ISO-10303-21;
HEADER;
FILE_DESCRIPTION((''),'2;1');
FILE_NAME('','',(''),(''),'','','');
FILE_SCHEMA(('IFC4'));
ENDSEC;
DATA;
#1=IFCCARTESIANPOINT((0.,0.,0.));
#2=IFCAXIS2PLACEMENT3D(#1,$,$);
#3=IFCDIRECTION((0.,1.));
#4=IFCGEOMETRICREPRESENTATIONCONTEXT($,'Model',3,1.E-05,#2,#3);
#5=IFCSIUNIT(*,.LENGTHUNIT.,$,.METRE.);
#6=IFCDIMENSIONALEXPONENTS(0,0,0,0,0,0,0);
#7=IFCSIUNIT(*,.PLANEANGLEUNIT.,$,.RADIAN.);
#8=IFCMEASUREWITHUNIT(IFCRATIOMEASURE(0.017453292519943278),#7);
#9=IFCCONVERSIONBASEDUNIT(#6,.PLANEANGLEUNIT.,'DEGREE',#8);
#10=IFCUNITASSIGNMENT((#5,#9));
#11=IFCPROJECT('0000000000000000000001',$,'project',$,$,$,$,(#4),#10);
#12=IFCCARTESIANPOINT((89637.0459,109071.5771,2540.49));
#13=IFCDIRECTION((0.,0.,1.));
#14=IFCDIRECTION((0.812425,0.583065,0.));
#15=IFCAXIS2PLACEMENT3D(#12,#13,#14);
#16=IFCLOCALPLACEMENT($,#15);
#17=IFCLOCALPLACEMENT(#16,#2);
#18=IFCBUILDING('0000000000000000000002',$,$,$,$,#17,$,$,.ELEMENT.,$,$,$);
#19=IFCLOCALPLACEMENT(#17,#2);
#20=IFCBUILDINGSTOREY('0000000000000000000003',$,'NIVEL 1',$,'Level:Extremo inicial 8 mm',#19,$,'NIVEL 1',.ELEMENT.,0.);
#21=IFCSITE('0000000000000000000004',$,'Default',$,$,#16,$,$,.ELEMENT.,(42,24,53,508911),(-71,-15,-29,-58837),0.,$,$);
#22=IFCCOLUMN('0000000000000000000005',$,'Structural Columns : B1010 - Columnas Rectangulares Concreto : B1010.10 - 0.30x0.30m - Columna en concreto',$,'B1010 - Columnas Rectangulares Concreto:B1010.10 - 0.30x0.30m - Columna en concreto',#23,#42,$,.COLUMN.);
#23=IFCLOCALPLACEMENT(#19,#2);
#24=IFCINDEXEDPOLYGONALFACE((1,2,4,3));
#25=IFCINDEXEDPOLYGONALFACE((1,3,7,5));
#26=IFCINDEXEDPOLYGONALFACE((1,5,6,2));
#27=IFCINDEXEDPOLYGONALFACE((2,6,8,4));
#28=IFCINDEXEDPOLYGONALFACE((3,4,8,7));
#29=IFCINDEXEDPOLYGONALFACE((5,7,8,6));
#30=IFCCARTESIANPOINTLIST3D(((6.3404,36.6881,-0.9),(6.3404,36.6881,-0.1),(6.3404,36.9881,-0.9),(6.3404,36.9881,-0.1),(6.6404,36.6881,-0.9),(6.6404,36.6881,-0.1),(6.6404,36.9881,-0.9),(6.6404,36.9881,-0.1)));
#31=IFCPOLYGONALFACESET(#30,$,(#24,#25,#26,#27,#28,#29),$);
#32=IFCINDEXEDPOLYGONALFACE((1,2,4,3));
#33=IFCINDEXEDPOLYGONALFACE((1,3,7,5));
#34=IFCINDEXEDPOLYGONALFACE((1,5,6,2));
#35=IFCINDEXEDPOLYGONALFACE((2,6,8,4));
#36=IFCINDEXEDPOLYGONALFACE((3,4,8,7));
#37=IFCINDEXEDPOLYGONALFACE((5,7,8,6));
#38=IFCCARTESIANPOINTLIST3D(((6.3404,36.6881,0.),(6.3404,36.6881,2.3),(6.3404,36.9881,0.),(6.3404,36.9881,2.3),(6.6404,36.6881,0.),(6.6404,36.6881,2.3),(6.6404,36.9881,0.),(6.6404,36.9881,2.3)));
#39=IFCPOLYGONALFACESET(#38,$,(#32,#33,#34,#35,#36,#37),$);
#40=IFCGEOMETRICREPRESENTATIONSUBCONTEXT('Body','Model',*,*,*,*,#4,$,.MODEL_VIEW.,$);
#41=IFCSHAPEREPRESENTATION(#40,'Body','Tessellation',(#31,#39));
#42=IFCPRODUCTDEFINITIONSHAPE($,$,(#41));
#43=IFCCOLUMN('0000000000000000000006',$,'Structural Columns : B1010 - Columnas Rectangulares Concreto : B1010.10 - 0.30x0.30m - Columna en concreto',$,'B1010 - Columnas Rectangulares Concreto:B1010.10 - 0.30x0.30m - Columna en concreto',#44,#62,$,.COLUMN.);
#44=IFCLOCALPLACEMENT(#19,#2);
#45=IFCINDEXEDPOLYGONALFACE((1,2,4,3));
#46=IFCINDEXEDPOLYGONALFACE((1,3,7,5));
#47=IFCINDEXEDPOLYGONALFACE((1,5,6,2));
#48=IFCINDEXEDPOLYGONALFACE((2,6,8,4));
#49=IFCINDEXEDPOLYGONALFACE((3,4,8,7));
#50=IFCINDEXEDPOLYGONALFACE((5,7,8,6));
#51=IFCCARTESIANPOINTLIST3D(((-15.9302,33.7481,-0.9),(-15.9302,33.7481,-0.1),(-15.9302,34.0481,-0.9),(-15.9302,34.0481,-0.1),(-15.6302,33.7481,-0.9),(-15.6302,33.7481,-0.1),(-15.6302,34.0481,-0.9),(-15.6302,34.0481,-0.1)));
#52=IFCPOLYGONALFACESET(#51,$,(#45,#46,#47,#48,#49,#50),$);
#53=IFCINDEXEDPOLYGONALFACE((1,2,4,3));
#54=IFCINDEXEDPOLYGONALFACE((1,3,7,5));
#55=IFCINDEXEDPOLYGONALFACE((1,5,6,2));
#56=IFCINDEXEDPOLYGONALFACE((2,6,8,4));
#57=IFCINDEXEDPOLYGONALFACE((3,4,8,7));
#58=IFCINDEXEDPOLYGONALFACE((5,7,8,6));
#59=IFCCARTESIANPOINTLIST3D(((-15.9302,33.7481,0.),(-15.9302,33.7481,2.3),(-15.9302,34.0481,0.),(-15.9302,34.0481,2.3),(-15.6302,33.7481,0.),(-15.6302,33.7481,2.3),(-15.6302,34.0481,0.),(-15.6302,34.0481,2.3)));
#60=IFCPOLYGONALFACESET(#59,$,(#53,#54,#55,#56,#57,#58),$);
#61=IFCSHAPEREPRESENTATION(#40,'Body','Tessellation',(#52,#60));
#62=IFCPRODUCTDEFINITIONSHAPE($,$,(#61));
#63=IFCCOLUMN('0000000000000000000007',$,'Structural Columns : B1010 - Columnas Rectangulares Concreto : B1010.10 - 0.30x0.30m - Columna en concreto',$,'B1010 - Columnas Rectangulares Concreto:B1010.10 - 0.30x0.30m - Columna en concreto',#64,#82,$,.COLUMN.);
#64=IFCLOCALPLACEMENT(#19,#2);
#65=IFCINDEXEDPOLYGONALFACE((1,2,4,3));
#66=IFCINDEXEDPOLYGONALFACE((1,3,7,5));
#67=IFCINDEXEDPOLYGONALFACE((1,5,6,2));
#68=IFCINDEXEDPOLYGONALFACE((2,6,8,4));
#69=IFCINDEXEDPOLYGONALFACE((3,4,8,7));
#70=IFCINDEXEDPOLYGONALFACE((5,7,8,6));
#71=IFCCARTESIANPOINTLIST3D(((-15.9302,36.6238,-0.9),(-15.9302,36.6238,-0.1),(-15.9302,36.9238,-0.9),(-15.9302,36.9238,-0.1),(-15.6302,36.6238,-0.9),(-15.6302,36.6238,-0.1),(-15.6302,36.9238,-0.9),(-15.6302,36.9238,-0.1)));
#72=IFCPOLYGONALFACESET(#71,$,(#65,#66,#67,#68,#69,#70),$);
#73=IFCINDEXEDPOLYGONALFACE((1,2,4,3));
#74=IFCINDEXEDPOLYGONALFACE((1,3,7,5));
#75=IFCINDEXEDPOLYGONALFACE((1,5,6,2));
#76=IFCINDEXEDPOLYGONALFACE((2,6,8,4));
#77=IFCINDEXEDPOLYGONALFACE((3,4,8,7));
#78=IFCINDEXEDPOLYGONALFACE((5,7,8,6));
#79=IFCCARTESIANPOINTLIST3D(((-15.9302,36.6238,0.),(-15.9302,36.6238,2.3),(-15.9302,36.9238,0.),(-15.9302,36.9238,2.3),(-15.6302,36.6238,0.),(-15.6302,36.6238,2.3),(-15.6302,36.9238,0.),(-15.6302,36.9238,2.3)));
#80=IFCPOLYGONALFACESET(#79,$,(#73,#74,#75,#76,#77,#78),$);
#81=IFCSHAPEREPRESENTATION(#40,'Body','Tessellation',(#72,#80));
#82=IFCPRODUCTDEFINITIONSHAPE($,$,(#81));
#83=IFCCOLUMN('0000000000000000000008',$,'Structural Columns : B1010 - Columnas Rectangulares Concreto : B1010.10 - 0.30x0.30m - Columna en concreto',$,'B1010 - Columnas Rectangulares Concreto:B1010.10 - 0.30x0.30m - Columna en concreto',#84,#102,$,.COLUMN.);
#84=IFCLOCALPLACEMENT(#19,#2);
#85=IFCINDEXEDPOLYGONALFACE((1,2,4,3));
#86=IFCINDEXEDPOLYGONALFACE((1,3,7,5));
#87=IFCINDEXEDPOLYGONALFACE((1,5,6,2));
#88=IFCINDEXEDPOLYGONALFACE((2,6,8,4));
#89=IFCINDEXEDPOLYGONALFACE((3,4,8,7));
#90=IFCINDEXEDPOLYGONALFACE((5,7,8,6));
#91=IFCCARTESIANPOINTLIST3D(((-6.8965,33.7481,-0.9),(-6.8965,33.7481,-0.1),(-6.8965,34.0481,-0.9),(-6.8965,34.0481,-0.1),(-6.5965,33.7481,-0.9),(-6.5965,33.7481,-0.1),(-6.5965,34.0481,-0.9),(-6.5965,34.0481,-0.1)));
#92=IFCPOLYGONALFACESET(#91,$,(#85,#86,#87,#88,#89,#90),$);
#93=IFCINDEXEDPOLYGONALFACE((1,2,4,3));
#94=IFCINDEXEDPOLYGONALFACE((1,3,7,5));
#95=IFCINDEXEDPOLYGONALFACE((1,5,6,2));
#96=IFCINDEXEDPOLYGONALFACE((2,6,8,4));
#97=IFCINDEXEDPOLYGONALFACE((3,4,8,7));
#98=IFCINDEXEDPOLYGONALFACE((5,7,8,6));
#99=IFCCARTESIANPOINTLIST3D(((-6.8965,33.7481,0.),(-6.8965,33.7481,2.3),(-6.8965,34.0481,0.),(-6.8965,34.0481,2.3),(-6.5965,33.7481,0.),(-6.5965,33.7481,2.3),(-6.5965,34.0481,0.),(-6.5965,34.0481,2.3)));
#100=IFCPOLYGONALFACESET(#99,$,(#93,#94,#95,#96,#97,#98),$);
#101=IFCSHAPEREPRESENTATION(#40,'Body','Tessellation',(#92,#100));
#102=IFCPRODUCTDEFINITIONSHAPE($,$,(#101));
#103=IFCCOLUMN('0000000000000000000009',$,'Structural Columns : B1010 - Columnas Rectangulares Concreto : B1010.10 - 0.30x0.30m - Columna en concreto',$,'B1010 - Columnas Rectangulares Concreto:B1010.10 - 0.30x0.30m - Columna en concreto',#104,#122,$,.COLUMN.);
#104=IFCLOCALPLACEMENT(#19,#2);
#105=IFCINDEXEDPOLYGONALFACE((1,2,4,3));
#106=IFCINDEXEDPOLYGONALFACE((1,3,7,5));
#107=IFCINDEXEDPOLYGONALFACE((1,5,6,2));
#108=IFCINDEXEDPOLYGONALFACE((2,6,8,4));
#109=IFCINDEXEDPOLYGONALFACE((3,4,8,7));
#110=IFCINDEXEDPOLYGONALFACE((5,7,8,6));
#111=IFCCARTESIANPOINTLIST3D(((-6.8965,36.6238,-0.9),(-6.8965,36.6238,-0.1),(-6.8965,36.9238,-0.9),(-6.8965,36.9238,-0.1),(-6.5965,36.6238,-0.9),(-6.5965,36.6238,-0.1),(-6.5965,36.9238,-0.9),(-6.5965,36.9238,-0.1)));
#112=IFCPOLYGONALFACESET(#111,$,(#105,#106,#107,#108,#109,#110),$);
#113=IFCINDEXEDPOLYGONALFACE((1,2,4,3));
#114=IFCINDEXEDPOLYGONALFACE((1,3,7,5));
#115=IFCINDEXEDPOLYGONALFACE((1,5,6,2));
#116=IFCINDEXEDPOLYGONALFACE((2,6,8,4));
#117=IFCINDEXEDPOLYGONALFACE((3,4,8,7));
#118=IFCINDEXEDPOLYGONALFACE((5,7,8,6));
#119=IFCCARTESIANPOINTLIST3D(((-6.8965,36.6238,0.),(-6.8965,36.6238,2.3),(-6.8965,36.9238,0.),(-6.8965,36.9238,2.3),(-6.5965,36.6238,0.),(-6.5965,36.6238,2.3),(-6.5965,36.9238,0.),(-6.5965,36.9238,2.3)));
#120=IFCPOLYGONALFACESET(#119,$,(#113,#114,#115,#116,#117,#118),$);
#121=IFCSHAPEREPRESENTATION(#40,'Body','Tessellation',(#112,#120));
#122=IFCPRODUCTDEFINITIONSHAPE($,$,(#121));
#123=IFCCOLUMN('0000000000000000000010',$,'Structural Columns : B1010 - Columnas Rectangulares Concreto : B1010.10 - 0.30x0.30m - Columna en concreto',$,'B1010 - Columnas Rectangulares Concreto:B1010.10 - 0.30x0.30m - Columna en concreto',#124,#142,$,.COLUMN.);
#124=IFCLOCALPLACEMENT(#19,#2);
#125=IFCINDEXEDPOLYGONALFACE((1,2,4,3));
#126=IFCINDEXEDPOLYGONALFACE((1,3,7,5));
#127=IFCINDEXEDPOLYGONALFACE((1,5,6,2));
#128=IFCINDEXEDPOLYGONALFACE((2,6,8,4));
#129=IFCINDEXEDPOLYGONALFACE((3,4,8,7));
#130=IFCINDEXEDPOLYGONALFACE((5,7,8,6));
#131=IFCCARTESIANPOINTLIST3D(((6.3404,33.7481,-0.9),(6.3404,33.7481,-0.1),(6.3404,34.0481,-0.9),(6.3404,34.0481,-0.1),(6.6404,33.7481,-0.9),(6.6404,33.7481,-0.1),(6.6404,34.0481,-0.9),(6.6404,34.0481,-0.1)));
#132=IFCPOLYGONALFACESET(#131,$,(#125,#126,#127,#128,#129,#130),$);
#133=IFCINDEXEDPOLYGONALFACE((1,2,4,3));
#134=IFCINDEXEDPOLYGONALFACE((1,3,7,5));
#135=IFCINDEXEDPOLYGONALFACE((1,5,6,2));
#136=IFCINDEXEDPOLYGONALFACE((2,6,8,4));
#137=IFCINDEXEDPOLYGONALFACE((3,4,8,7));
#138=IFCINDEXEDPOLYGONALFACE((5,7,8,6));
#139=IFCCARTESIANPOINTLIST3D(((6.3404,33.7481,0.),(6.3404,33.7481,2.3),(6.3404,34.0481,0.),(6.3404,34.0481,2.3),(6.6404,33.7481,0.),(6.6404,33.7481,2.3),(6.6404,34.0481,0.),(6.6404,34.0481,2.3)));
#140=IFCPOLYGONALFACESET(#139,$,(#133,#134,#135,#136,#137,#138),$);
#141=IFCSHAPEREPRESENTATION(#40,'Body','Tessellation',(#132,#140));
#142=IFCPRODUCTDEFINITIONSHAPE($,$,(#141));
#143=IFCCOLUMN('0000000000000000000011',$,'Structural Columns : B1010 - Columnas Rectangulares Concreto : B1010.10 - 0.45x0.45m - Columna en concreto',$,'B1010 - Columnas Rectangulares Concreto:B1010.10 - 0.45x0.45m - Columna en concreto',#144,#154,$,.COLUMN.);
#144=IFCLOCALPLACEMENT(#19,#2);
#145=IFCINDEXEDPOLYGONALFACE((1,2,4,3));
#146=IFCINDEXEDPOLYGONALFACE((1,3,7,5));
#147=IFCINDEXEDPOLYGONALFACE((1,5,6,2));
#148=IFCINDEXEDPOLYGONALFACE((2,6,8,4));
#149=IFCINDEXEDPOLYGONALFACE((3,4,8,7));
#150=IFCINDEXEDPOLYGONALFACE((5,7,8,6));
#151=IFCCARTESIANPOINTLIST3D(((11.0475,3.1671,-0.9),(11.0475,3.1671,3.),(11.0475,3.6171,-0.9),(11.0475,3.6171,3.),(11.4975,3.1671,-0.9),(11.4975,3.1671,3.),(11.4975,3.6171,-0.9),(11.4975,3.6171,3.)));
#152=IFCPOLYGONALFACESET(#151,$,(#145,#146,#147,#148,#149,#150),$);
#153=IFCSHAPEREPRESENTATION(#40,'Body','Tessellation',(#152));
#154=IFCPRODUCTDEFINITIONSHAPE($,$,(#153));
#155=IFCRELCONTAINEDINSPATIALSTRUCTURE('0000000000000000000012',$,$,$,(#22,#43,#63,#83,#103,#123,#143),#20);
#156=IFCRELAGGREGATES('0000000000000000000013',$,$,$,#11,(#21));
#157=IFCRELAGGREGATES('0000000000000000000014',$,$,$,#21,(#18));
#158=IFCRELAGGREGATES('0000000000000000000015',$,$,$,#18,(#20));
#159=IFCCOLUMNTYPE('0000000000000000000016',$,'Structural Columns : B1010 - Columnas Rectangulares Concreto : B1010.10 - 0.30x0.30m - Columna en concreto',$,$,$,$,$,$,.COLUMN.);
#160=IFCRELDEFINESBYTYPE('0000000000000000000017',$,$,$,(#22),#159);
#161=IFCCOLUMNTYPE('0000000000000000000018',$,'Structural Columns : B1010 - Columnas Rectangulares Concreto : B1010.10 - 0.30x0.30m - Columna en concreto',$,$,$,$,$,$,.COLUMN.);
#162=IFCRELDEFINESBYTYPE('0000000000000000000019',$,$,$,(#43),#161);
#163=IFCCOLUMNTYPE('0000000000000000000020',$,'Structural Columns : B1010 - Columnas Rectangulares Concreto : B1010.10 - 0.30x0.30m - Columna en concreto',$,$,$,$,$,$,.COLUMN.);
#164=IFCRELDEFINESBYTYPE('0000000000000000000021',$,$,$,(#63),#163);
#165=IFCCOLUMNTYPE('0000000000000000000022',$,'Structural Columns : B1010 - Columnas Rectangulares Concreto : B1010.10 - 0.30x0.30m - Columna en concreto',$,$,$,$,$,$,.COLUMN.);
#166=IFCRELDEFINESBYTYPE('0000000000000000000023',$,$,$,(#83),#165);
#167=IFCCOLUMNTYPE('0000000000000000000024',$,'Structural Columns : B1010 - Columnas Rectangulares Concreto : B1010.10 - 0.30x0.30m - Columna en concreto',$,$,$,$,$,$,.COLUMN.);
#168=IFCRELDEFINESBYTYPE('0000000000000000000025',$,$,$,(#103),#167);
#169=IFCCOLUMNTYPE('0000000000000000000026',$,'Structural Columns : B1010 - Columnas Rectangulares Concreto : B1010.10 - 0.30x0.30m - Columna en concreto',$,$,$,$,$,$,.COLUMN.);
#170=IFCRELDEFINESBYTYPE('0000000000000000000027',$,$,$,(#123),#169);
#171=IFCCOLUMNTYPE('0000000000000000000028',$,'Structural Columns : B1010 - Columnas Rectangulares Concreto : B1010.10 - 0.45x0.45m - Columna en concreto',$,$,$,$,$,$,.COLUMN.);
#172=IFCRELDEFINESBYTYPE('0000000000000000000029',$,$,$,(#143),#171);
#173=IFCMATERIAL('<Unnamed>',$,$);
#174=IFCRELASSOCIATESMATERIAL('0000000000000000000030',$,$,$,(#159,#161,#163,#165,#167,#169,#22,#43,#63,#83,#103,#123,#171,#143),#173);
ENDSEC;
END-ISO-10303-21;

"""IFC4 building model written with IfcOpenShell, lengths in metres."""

from ifc_helpers import new_model, entity, si_unit, converted_unit, direction, frame, frame_2d, origin, origin_2d_with_axis, place, context, subcontext, project, spatial, polyline, segment, composite_curve, rectangle, outline, extrude, source, transform, mapped, material, material_profile, profile_set, profile_usage, type_object, type_shapes, element, save


model = new_model("IFC4")

# Units and contexts
model_context = context("Model", 3, precision=1e-05, world=origin(), true_north=direction((0.0, 1.0)))
body_context = subcontext(model_context, "Body", "Model", "MODEL_VIEW")
ifc_project = project(units=[si_unit("LENGTHUNIT", "METRE"), converted_unit("PLANEANGLEUNIT", "DEGREE", entity("IfcRatioMeasure", 0.017453292519943278), si_unit("PLANEANGLEUNIT", "RADIAN"), dimensions=[0, 0, 0, 0, 0, 0, 0])], contexts=[model_context])

# Site, building, storey
site_placement = place(None, frame((89637.0459, 109071.5771, 2540.49), z_axis=(0.0, 0.0, 1.0), x_axis=(0.812425, 0.583065, 0.0)))
site = spatial("IfcSite", under=ifc_project, at=site_placement, Name="Default", CompositionType="ELEMENT", RefLatitude=(42, 24, 53, 508911), RefLongitude=(-71, -15, -29, -58837), RefElevation=0.0)
building_placement = place(site_placement, origin())
building = spatial("IfcBuilding", under=site, at=building_placement, CompositionType="ELEMENT")
storey_placement = place(building_placement, origin())
storey = spatial("IfcBuildingStorey", under=building, at=storey_placement, Name="NIVEL 1", ObjectType="Level:Extremo inicial 8 mm", LongName="NIVEL 1", CompositionType="ELEMENT", Elevation=0.0)

# Columns
ifc_material = material(Name="<Unnamed>")
ifc_material_profile_1 = material_profile(ifc_material, outline(composite_curve([segment(polyline([(0.225, 0.225, 0.0), (0.225, -0.225, 0.0)]), True, "CONTINUOUS"), segment(polyline([(0.225, -0.225, 0.0), (-0.225, -0.225, 0.0)]), True, "CONTINUOUS"), segment(polyline([(-0.225, -0.225, 0.0), (-0.225, 0.225, 0.0)]), True, "CONTINUOUS"), segment(polyline([(-0.225, 0.225, 0.0), (0.225, 0.225, 0.0)]), True, "CONTINUOUS")], self_intersect=False), kind="CURVE"), Name="B1010.10 - 0.45x0.45m - Columna en concreto")
ifc_material_profile_2 = material_profile(ifc_material, outline(composite_curve([segment(polyline([(0.225, 0.225, 3.0), (-0.225, 0.225, 3.0)]), True, "CONTINUOUS"), segment(polyline([(-0.225, 0.225, 3.0), (-0.225, -0.225, 3.0)]), True, "CONTINUOUS"), segment(polyline([(-0.225, -0.225, 3.0), (0.225, -0.225, 3.0)]), True, "CONTINUOUS"), segment(polyline([(0.225, -0.225, 3.0), (0.225, 0.225, 3.0)]), True, "CONTINUOUS")], self_intersect=False), kind="CURVE"), Name="B1010.10 - 0.45x0.45m - Columna en concreto")
ifc_profile_set_1 = profile_set([ifc_material_profile_1, ifc_material_profile_2], Name="B1010.10 - 0.45x0.45m - Columna en concreto")
ifc_material_profile_3 = material_profile(ifc_material, outline(composite_curve([segment(polyline([(0.15, 0.15, 0.0), (0.15, -0.15, 0.0)]), True, "CONTINUOUS"), segment(polyline([(0.15, -0.15, 0.0), (-0.15, -0.15, 0.0)]), True, "CONTINUOUS"), segment(polyline([(-0.15, -0.15, 0.0), (-0.15, 0.15, 0.0)]), True, "CONTINUOUS"), segment(polyline([(-0.15, 0.15, 0.0), (0.15, 0.15, 0.0)]), True, "CONTINUOUS")], self_intersect=False), kind="CURVE"), Name="B1010.10 - 0.30x0.30m - Columna en concreto")
ifc_material_profile_4 = material_profile(ifc_material, outline(composite_curve([segment(polyline([(0.15, 0.15, 2.3), (-0.15, 0.15, 2.3)]), True, "CONTINUOUS"), segment(polyline([(-0.15, 0.15, 2.3), (-0.15, -0.15, 2.3)]), True, "CONTINUOUS"), segment(polyline([(-0.15, -0.15, 2.3), (0.15, -0.15, 2.3)]), True, "CONTINUOUS"), segment(polyline([(0.15, -0.15, 2.3), (0.15, 0.15, 2.3)]), True, "CONTINUOUS")], self_intersect=False), kind="CURVE"), Name="B1010.10 - 0.30x0.30m - Columna en concreto")
ifc_profile_set_2 = profile_set([ifc_material_profile_3, ifc_material_profile_4], Name="B1010.10 - 0.30x0.30m - Columna en concreto")
ifc_profile_usage_1 = profile_usage(ifc_profile_set_2)
column_type_1 = type_object("IfcColumnType", Name="Structural Columns : B1010 - Columnas Rectangulares Concreto : B1010.10 - 0.30x0.30m - Columna en concreto", PredefinedType="COLUMN", material=ifc_profile_set_2)
shared_shape_1 = source(origin(), body_context, "Body", "SweptSolid", [
    extrude(rectangle(XDim=0.3, YDim=0.3, at=frame_2d((0.0, 0.0), x_axis=(1.0, 0.0))), frame((6.4904, 36.8381, -0.9), z_axis=(0.0, 0.0, 1.0), x_axis=(0.0, -1.0, 0.0)), (0.0, 0.0, 1.0), 0.8),
    extrude(rectangle(XDim=0.3, YDim=0.3, at=frame_2d((0.0, 0.0), x_axis=(1.0, 0.0))), frame((6.4904, 36.8381, 0.0), z_axis=(0.0, 0.0, 1.0), x_axis=(0.0, -1.0, 0.0)), (0.0, 0.0, 1.0), 2.3),
])
type_shapes(column_type_1, [shared_shape_1])
column_1_placement = place(storey_placement, origin())
element("IfcColumn", 1, at=column_1_placement, inside=storey, type_object=column_type_1, material=ifc_profile_usage_1, Name="Structural Columns : B1010 - Columnas Rectangulares Concreto : B1010.10 - 0.30x0.30m - Columna en concreto", ObjectType="B1010 - Columnas Rectangulares Concreto:B1010.10 - 0.30x0.30m - Columna en concreto", PredefinedType="COLUMN", context=body_context, shape_type="MappedRepresentation", body=[
    mapped(shared_shape_1, transform((0.0, 0.0, 0.0), scale=1.0)),
])
ifc_profile_usage_2 = profile_usage(ifc_profile_set_2)
column_type_2 = type_object("IfcColumnType", Name="Structural Columns : B1010 - Columnas Rectangulares Concreto : B1010.10 - 0.30x0.30m - Columna en concreto", PredefinedType="COLUMN", material=ifc_profile_set_2)
shared_shape_2 = source(origin(), body_context, "Body", "SweptSolid", [
    extrude(rectangle(XDim=0.3, YDim=0.3, at=origin_2d_with_axis()), frame((-15.7802, 33.8981, -0.9), z_axis=(0.0, 0.0, 1.0), x_axis=(0.0, -1.0, 0.0)), (0.0, 0.0, 1.0), 0.8),
    extrude(rectangle(XDim=0.3, YDim=0.3, at=origin_2d_with_axis()), frame((-15.7802, 33.8981, 0.0), z_axis=(0.0, 0.0, 1.0), x_axis=(0.0, -1.0, 0.0)), (0.0, 0.0, 1.0), 2.3),
])
type_shapes(column_type_2, [shared_shape_2])
column_2_placement = place(storey_placement, origin())
element("IfcColumn", 2, at=column_2_placement, inside=storey, type_object=column_type_2, material=ifc_profile_usage_2, Name="Structural Columns : B1010 - Columnas Rectangulares Concreto : B1010.10 - 0.30x0.30m - Columna en concreto", ObjectType="B1010 - Columnas Rectangulares Concreto:B1010.10 - 0.30x0.30m - Columna en concreto", PredefinedType="COLUMN", context=body_context, shape_type="MappedRepresentation", body=[
    mapped(shared_shape_2, transform((0.0, 0.0, 0.0), scale=1.0)),
])
ifc_profile_usage_3 = profile_usage(ifc_profile_set_2)
column_type_3 = type_object("IfcColumnType", Name="Structural Columns : B1010 - Columnas Rectangulares Concreto : B1010.10 - 0.30x0.30m - Columna en concreto", PredefinedType="COLUMN", material=ifc_profile_set_2)
shared_shape_3 = source(origin(), body_context, "Body", "SweptSolid", [
    extrude(rectangle(XDim=0.3, YDim=0.3, at=origin_2d_with_axis()), frame((-15.7802, 36.7738, -0.9), z_axis=(0.0, 0.0, 1.0), x_axis=(0.0, -1.0, 0.0)), (0.0, 0.0, 1.0), 0.8),
    extrude(rectangle(XDim=0.3, YDim=0.3, at=origin_2d_with_axis()), frame((-15.7802, 36.7738, 0.0), z_axis=(0.0, 0.0, 1.0), x_axis=(0.0, -1.0, 0.0)), (0.0, 0.0, 1.0), 2.3),
])
type_shapes(column_type_3, [shared_shape_3])
column_3_placement = place(storey_placement, origin())
element("IfcColumn", 3, at=column_3_placement, inside=storey, type_object=column_type_3, material=ifc_profile_usage_3, Name="Structural Columns : B1010 - Columnas Rectangulares Concreto : B1010.10 - 0.30x0.30m - Columna en concreto", ObjectType="B1010 - Columnas Rectangulares Concreto:B1010.10 - 0.30x0.30m - Columna en concreto", PredefinedType="COLUMN", context=body_context, shape_type="MappedRepresentation", body=[
    mapped(shared_shape_3, transform((0.0, 0.0, 0.0), scale=1.0)),
])
ifc_profile_usage_4 = profile_usage(ifc_profile_set_2)
column_type_4 = type_object("IfcColumnType", Name="Structural Columns : B1010 - Columnas Rectangulares Concreto : B1010.10 - 0.30x0.30m - Columna en concreto", PredefinedType="COLUMN", material=ifc_profile_set_2)
shared_shape_4 = source(origin(), body_context, "Body", "SweptSolid", [
    extrude(rectangle(XDim=0.3, YDim=0.3, at=frame_2d((0.0, 0.0), x_axis=(1.0, 0.0))), frame((-6.7465, 33.8981, -0.9), z_axis=(0.0, 0.0, 1.0), x_axis=(0.0, -1.0, 0.0)), (0.0, 0.0, 1.0), 0.8),
    extrude(rectangle(XDim=0.3, YDim=0.3, at=frame_2d((0.0, 0.0), x_axis=(1.0, 0.0))), frame((-6.7465, 33.8981, 0.0), z_axis=(0.0, 0.0, 1.0), x_axis=(0.0, -1.0, 0.0)), (0.0, 0.0, 1.0), 2.3),
])
type_shapes(column_type_4, [shared_shape_4])
column_4_placement = place(storey_placement, origin())
element("IfcColumn", 4, at=column_4_placement, inside=storey, type_object=column_type_4, material=ifc_profile_usage_4, Name="Structural Columns : B1010 - Columnas Rectangulares Concreto : B1010.10 - 0.30x0.30m - Columna en concreto", ObjectType="B1010 - Columnas Rectangulares Concreto:B1010.10 - 0.30x0.30m - Columna en concreto", PredefinedType="COLUMN", context=body_context, shape_type="MappedRepresentation", body=[
    mapped(shared_shape_4, transform((0.0, 0.0, 0.0), scale=1.0)),
])
ifc_profile_usage_5 = profile_usage(ifc_profile_set_2)
column_type_5 = type_object("IfcColumnType", Name="Structural Columns : B1010 - Columnas Rectangulares Concreto : B1010.10 - 0.30x0.30m - Columna en concreto", PredefinedType="COLUMN", material=ifc_profile_set_2)
shared_shape_5 = source(origin(), body_context, "Body", "SweptSolid", [
    extrude(rectangle(XDim=0.3, YDim=0.3, at=frame_2d((0.0, 0.0), x_axis=(1.0, 0.0))), frame((-6.7465, 36.7738, -0.9), z_axis=(0.0, 0.0, 1.0), x_axis=(0.0, -1.0, 0.0)), (0.0, 0.0, 1.0), 0.8),
    extrude(rectangle(XDim=0.3, YDim=0.3, at=frame_2d((0.0, 0.0), x_axis=(1.0, 0.0))), frame((-6.7465, 36.7738, 0.0), z_axis=(0.0, 0.0, 1.0), x_axis=(0.0, -1.0, 0.0)), (0.0, 0.0, 1.0), 2.3),
])
type_shapes(column_type_5, [shared_shape_5])
column_5_placement = place(storey_placement, origin())
element("IfcColumn", 5, at=column_5_placement, inside=storey, type_object=column_type_5, material=ifc_profile_usage_5, Name="Structural Columns : B1010 - Columnas Rectangulares Concreto : B1010.10 - 0.30x0.30m - Columna en concreto", ObjectType="B1010 - Columnas Rectangulares Concreto:B1010.10 - 0.30x0.30m - Columna en concreto", PredefinedType="COLUMN", context=body_context, shape_type="MappedRepresentation", body=[
    mapped(shared_shape_5, transform((0.0, 0.0, 0.0), scale=1.0)),
])
ifc_profile_usage_6 = profile_usage(ifc_profile_set_2)
column_type_6 = type_object("IfcColumnType", Name="Structural Columns : B1010 - Columnas Rectangulares Concreto : B1010.10 - 0.30x0.30m - Columna en concreto", PredefinedType="COLUMN", material=ifc_profile_set_2)
shared_shape_6 = source(origin(), body_context, "Body", "SweptSolid", [
    extrude(rectangle(XDim=0.3, YDim=0.3, at=frame_2d((0.0, 0.0), x_axis=(1.0, 0.0))), frame((6.4904, 33.8981, -0.9), z_axis=(0.0, 0.0, 1.0), x_axis=(0.0, -1.0, 0.0)), (0.0, 0.0, 1.0), 0.8),
    extrude(rectangle(XDim=0.3, YDim=0.3, at=frame_2d((0.0, 0.0), x_axis=(1.0, 0.0))), frame((6.4904, 33.8981, 0.0), z_axis=(0.0, 0.0, 1.0), x_axis=(0.0, -1.0, 0.0)), (0.0, 0.0, 1.0), 2.3),
])
type_shapes(column_type_6, [shared_shape_6])
column_6_placement = place(storey_placement, origin())
element("IfcColumn", 6, at=column_6_placement, inside=storey, type_object=column_type_6, material=ifc_profile_usage_6, Name="Structural Columns : B1010 - Columnas Rectangulares Concreto : B1010.10 - 0.30x0.30m - Columna en concreto", ObjectType="B1010 - Columnas Rectangulares Concreto:B1010.10 - 0.30x0.30m - Columna en concreto", PredefinedType="COLUMN", context=body_context, shape_type="MappedRepresentation", body=[
    mapped(shared_shape_6, transform((0.0, 0.0, 0.0), scale=1.0)),
])
ifc_profile_usage_7 = profile_usage(ifc_profile_set_1)
column_type_7 = type_object("IfcColumnType", Name="Structural Columns : B1010 - Columnas Rectangulares Concreto : B1010.10 - 0.45x0.45m - Columna en concreto", PredefinedType="COLUMN", material=ifc_profile_set_1)
shared_shape_7 = source(origin(), body_context, "Body", "SweptSolid", [
    extrude(rectangle(XDim=0.45, YDim=0.45, at=frame_2d((0.0, 0.0), x_axis=(1.0, 0.0))), frame((11.2725, 3.3921, -0.9), z_axis=(0.0, 0.0, 1.0), x_axis=(0.0, -1.0, 0.0)), (0.0, 0.0, 1.0), 3.9),
])
type_shapes(column_type_7, [shared_shape_7])
column_7_placement = place(storey_placement, origin())
element("IfcColumn", 7, at=column_7_placement, inside=storey, type_object=column_type_7, material=ifc_profile_usage_7, Name="Structural Columns : B1010 - Columnas Rectangulares Concreto : B1010.10 - 0.45x0.45m - Columna en concreto", ObjectType="B1010 - Columnas Rectangulares Concreto:B1010.10 - 0.45x0.45m - Columna en concreto", PredefinedType="COLUMN", context=body_context, shape_type="MappedRepresentation", body=[
    mapped(shared_shape_7, transform((0.0, 0.0, 0.0), scale=1.0)),
])

save(model, "model.ifc")
